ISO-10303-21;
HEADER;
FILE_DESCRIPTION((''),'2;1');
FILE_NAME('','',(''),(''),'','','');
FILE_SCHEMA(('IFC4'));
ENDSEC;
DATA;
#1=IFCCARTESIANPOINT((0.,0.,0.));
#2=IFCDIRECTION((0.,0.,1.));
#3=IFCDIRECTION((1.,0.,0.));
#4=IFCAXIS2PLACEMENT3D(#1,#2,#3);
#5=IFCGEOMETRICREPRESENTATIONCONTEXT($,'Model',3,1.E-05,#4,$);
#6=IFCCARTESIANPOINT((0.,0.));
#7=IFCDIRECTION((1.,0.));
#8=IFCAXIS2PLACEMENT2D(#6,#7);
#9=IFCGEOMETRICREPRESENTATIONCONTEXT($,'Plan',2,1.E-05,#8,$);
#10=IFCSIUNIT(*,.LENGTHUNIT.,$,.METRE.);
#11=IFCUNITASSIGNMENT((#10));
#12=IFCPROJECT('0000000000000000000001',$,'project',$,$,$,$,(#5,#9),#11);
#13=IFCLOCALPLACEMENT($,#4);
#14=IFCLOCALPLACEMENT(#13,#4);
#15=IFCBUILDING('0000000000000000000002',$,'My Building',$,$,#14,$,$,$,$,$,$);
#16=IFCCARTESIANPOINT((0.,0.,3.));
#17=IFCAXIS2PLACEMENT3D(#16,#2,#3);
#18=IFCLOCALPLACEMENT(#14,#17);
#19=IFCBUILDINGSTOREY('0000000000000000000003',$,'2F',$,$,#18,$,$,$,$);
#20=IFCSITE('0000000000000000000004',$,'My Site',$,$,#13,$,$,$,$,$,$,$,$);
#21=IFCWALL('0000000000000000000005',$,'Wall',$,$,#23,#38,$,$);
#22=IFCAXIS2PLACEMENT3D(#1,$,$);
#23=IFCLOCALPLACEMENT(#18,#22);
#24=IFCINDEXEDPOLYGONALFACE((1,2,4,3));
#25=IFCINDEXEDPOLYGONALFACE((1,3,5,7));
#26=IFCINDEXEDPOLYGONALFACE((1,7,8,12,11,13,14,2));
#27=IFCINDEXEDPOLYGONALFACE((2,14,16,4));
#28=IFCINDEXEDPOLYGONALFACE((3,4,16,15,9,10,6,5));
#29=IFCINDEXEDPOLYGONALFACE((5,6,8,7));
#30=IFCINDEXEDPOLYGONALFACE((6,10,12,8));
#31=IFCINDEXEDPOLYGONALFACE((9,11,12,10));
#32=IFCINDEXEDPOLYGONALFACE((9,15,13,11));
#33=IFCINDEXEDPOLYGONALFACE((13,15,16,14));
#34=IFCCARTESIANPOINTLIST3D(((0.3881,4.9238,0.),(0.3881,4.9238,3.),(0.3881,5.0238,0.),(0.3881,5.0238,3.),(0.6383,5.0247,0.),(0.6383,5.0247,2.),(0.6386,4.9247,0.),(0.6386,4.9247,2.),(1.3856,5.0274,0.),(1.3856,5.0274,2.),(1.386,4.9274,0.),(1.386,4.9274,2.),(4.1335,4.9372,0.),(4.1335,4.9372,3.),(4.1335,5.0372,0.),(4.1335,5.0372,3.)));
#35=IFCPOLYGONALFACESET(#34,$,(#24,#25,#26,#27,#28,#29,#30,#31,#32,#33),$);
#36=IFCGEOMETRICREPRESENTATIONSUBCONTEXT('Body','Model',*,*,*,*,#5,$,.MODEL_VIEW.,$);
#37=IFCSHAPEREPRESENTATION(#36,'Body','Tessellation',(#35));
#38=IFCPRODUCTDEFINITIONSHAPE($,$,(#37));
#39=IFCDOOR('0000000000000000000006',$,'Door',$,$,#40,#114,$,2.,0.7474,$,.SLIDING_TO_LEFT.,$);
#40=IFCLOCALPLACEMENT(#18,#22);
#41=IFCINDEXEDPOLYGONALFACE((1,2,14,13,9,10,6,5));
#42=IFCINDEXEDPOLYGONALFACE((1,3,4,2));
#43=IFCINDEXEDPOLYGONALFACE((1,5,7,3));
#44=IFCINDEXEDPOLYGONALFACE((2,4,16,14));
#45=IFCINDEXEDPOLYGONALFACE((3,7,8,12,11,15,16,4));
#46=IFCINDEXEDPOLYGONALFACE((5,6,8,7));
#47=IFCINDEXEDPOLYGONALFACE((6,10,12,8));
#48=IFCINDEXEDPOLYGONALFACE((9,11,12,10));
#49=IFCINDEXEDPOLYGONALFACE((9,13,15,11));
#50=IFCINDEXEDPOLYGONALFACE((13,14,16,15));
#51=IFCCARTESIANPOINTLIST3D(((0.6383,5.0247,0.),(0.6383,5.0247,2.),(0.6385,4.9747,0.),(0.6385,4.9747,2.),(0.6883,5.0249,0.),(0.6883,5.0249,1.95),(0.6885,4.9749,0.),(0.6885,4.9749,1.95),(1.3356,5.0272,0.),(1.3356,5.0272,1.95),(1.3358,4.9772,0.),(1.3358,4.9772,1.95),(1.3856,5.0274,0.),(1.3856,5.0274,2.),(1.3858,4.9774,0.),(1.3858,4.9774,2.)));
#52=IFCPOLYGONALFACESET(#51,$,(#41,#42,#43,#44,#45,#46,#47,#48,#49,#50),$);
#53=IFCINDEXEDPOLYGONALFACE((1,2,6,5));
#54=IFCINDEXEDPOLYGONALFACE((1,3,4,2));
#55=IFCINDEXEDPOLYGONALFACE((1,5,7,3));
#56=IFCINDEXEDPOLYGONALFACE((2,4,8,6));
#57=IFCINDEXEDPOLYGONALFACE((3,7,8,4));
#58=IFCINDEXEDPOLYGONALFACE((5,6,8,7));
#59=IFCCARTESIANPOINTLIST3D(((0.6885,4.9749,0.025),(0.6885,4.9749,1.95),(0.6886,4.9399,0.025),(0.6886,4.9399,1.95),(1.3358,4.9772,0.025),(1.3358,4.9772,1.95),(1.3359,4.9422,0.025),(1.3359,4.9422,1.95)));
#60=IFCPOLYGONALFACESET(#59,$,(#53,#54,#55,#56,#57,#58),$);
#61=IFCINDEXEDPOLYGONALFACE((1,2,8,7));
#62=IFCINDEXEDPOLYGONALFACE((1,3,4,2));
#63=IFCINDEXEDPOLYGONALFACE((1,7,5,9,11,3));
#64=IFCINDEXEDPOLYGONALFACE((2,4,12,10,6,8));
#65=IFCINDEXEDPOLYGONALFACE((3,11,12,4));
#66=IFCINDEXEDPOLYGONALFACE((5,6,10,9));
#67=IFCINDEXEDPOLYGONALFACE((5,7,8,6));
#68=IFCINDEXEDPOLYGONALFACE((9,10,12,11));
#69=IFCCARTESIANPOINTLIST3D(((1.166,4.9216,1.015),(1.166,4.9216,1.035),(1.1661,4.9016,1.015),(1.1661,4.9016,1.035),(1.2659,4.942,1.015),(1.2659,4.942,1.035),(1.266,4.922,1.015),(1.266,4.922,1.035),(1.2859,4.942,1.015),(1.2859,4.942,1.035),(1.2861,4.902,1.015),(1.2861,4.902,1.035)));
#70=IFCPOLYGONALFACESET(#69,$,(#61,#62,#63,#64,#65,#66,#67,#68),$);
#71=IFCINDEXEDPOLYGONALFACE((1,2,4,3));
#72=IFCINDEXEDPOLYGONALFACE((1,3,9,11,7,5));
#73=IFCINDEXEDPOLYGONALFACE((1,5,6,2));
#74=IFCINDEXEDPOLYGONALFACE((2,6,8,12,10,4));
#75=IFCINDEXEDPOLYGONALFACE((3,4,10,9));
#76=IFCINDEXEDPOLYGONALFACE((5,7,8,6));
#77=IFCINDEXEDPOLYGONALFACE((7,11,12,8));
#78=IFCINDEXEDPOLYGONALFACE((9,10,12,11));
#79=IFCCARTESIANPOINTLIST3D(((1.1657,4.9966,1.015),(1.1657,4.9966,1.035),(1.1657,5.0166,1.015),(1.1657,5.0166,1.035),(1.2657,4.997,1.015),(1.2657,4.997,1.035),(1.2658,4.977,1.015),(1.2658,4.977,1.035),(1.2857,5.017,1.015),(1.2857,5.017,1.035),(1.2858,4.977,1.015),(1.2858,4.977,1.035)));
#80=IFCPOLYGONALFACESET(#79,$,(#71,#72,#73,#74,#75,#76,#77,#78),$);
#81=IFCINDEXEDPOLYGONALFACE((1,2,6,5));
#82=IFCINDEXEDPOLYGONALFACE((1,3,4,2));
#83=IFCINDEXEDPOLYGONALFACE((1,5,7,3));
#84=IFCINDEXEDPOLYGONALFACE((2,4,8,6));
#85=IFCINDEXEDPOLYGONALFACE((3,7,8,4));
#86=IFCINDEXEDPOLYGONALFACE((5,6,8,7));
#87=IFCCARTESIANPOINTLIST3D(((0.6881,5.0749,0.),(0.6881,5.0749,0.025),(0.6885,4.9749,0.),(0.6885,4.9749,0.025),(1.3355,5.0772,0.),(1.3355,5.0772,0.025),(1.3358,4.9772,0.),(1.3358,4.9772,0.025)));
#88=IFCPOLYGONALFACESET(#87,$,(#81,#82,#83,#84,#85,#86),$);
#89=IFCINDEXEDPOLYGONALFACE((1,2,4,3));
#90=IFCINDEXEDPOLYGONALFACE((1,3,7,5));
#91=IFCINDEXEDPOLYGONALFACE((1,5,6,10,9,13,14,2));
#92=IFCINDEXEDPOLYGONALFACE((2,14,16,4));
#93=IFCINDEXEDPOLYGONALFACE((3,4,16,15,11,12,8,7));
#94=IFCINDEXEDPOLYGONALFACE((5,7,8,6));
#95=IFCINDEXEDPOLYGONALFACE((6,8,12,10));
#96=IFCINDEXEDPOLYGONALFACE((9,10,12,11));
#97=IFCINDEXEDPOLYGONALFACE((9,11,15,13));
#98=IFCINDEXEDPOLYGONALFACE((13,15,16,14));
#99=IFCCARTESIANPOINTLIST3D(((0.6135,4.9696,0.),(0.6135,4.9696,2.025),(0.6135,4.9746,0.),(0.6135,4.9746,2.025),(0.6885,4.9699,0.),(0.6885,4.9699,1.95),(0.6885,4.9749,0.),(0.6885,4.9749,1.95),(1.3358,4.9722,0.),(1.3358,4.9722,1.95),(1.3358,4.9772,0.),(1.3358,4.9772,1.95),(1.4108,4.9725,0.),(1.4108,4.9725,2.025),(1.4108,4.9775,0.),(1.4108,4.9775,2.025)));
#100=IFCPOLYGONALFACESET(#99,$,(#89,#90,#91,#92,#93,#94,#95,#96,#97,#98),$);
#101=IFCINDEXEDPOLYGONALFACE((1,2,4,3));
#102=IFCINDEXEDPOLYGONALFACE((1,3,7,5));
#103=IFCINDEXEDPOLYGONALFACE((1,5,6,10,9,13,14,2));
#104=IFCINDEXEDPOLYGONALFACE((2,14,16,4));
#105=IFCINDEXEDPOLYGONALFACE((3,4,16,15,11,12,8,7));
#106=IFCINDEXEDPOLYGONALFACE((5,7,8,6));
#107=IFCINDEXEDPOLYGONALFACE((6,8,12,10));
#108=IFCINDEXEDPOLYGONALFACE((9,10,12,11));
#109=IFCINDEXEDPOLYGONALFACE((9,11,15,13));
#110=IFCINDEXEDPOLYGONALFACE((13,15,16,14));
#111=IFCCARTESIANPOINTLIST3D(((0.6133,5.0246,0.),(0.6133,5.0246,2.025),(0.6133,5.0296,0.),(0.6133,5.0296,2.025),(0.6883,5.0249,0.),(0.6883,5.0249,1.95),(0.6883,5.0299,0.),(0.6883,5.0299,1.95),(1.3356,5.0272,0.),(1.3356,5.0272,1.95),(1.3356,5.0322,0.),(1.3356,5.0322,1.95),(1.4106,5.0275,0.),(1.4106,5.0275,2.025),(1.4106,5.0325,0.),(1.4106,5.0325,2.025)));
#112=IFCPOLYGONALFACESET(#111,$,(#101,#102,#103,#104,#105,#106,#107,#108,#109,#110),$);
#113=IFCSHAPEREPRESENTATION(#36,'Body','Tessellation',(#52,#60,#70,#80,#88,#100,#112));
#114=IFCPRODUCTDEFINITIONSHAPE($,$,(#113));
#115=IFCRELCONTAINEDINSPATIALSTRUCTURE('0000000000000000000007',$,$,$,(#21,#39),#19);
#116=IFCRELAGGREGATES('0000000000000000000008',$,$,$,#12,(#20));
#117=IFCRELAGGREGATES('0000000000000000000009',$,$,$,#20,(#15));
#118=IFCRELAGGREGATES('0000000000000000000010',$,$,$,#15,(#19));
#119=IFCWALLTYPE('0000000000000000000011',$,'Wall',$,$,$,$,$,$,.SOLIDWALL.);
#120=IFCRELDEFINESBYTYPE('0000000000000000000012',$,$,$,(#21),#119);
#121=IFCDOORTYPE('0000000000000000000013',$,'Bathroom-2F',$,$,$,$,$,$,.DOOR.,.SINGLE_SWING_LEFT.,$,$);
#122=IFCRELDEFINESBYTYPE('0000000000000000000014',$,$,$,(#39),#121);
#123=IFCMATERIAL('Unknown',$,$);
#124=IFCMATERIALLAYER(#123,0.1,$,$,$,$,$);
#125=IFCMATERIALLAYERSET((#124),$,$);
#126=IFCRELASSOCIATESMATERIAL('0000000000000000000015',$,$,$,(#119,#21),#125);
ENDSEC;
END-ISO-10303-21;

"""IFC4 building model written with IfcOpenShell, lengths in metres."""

from ifc_helpers import new_model, entity, si_unit, frame, origin_with_axes, origin_2d_with_axis, place, context, subcontext, project, spatial, line, indexed_curve, outline, extrude, shape, source, transform, mapped, material, layer, layer_set, layer_usage, type_object, type_shapes, element, fill, save


model = new_model("IFC4")

# Units and contexts
model_context = context("Model", 3, precision=1e-05, world=origin_with_axes())
plan_context = context("Plan", 2, precision=1e-05, world=origin_2d_with_axis())
body_context_1 = subcontext(model_context, "Body", "Model", "MODEL_VIEW")
body_context_2 = subcontext(plan_context, "Body", "Plan", "PLAN_VIEW")
ifc_project = project(units=[si_unit("LENGTHUNIT", "METRE")], contexts=[model_context, plan_context])

# Site, building, storey
site_placement = place(None, origin_with_axes())
site = spatial("IfcSite", under=ifc_project, at=site_placement, Name="My Site")
building_placement = place(site_placement, origin_with_axes())
building = spatial("IfcBuilding", under=site, at=building_placement, Name="My Building")
storey_placement = place(building_placement, frame((0.0, 0.0, 3.0), z_axis=(0.0, 0.0, 1.0), x_axis=(1.0, 0.0, 0.0)))
storey = spatial("IfcBuildingStorey", under=building, at=storey_placement, Name="2F")

# Shared definitions
ifc_material = material(Name="Unknown")

# Shared definitions
ifc_layer_1 = layer(ifc_material, 0.1)
ifc_layer_set_1 = layer_set([ifc_layer_1])
wall_type = type_object("IfcWallType", Name="Wall", PredefinedType="SOLIDWALL", material=ifc_layer_set_1)

# Wall, opening, door
ifc_layer_usage_1 = layer_usage(ifc_layer_set_1, "AXIS2", "POSITIVE", 0.0)
wall_1_placement = place(storey_placement, frame((0.3881, 4.9238, 0.0), z_axis=(0.0, 0.0, 1.0), x_axis=(0.999994, 0.003582, 0.0)))
wall_1 = element("IfcWall", 1, at=wall_1_placement, inside=storey, type_object=wall_type, material=ifc_layer_usage_1, Name="Wall", context=body_context_1, shape_type="SweptSolid", body=[
    extrude(outline(indexed_curve([(0.0, 0.0), (0.0004, 0.1), (3.7458, 0.1), (3.7454, 0.0)], segments=[line(1, 2, 3, 4, 1)])), origin_with_axes(), (0.0, 0.0, 1.0), 3.0),
])
shared_shape_1 = source(origin_with_axes(), body_context_1, "Body", "SweptSolid", [
    extrude(outline(indexed_curve([(0.0, 0.0), (0.7474, 0.0), (0.7474, 2.0), (0.0, 2.0)], segments=[line(1, 2, 3, 4, 1)])), frame((0.0, -0.6, 0.0), z_axis=(0.0, -1.0, 0.0), x_axis=(1.0, 0.0, 0.0)), (0.0, 0.0, -1.0), 1.2),
])
opening_1_placement = place(wall_1_placement, frame((0.2505, 0.05, 0.0), z_axis=(0.0, 0.0, 1.0), x_axis=(1.0, -0.000001, 0.0)))
opening_1 = element("IfcOpeningElement", 2, at=opening_1_placement, cuts=wall_1, PredefinedType="OPENING", context=body_context_1, shape_type="MappedRepresentation", body=[
    mapped(shared_shape_1, transform((0.0, 0.0, 0.0), x_axis=(1.0, 0.0, 0.0), y_axis=(0.0, 1.0, 0.0), z_axis=(0.0, 0.0, 1.0), scale=1.0)),
])
door_type_1 = type_object("IfcDoorType", Name="Bathroom-2F", OperationType="SINGLE_SWING_LEFT", PredefinedType="DOOR")
shared_shape_2 = source(origin_with_axes(), body_context_1, "Body", "SweptSolid", [
    extrude(outline(indexed_curve([(0.0, 0.0), (0.0, 2.0), (0.7474, 2.0), (0.7474, 0.0), (0.6974, 0.0), (0.6974, 1.95), (0.05, 1.95), (0.05, 0.0)], segments=[line(1, 2, 3, 4, 5, 6, 7, 8, 1)])), frame((0.0, 0.0, 0.0), z_axis=(0.0, -1.0, 0.0), x_axis=(1.0, 0.0, 0.0)), (0.0, 0.0, -1.0), 0.05),
    extrude(outline(indexed_curve([(0.0, 0.0), (0.6474, 0.0), (0.6474, 0.035), (0.0, 0.035)], segments=[line(1, 2, 3, 4, 1)])), frame((0.05, -0.035, 0.025), z_axis=(0.0, 0.0, 1.0), x_axis=(1.0, 0.0, 0.0)), (0.0, 0.0, 1.0), 1.925),
    extrude(outline(indexed_curve([(0.0, 0.0), (0.0, -0.04), (-0.12, -0.04), (-0.12, -0.02), (-0.02, -0.02), (-0.02, 0.0)], segments=[line(1, 2, 3, 4, 5, 6, 1)])), frame((0.6474, -0.035, 1.015), z_axis=(0.0, 0.0, 1.0), x_axis=(1.0, 0.0, 0.0)), (0.0, 0.0, 1.0), 0.02),
    extrude(outline(indexed_curve([(0.0, 0.0), (0.0, 0.04), (-0.12, 0.04), (-0.12, 0.02), (-0.02, 0.02), (-0.02, 0.0)], segments=[line(1, 2, 3, 4, 5, 6, 1)])), frame((0.6474, 0.0, 1.015), z_axis=(0.0, 0.0, 1.0), x_axis=(1.0, 0.0, 0.0)), (0.0, 0.0, 1.0), 0.02),
    extrude(outline(indexed_curve([(0.0, 0.0), (0.6474, 0.0), (0.6474, 0.1), (0.0, 0.1)], segments=[line(1, 2, 3, 4, 1)])), frame((0.05, 0.0, 0.0), z_axis=(0.0, 0.0, 1.0), x_axis=(1.0, 0.0, 0.0)), (0.0, 0.0, 1.0), 0.025),
    extrude(outline(indexed_curve([(0.0, 0.0), (0.0, 2.025), (0.7974, 2.025), (0.7974, 0.0), (0.7224, 0.0), (0.7224, 1.95), (0.075, 1.95), (0.075, 0.0)], segments=[line(1, 2, 3, 4, 5, 6, 7, 8, 1)])), frame((-0.025, -0.005, 0.0), z_axis=(0.0, -1.0, 0.0), x_axis=(1.0, 0.0, 0.0)), (0.0, 0.0, -1.0), 0.005),
    extrude(outline(indexed_curve([(0.0, 0.0), (0.0, 2.025), (0.7974, 2.025), (0.7974, 0.0), (0.7224, 0.0), (0.7224, 1.95), (0.075, 1.95), (0.075, 0.0)], segments=[line(1, 2, 3, 4, 5, 6, 7, 8, 1)])), frame((-0.025, 0.05, 0.0), z_axis=(0.0, -1.0, 0.0), x_axis=(1.0, 0.0, 0.0)), (0.0, 0.0, -1.0), 0.005),
])
shared_shape_3 = source(origin_with_axes(), body_context_2, "Body", "Curve2D", [
    entity("IfcIndexedPolyCurve", entity("IfcCartesianPointList2D", [[0.0, 0.0], [0.05, 0.0], [0.05, 0.05], [0.0, 0.05]]), [entity("IfcLineIndex", [1, 2, 3, 4, 1])]),
    entity("IfcIndexedPolyCurve", entity("IfcCartesianPointList2D", [[0.7474, 0.0], [0.6974, 0.0], [0.6974, 0.05], [0.7474, 0.05]]), [entity("IfcLineIndex", [1, 2, 3, 4, 1])]),
    entity("IfcIndexedPolyCurve", entity("IfcCartesianPointList2D", [[-0.2737, -0.035], [0.3737, -0.035], [0.3737, 0.0], [-0.2737, 0.0]]), [entity("IfcLineIndex", [1, 2, 3, 4, 1])]),
])
type_shapes(door_type_1, [shared_shape_2, shared_shape_3])
door_1_placement = place(opening_1_placement, frame((0.0, 0.0, 0.0), z_axis=(0.0, 0.0, 1.0), x_axis=(1.0, 0.0, 0.0)))
door_1 = element("IfcDoor", 3, at=door_1_placement, inside=storey, type_object=door_type_1, Name="Door", OperationType="SLIDING_TO_LEFT", OverallHeight=2.0, OverallWidth=0.7474, shapes=[
    shape(body_context_1, "Body", "MappedRepresentation", [mapped(shared_shape_2, transform((0.0, 0.0, 0.0), x_axis=(1.0, 0.0, 0.0), y_axis=(0.0, 1.0, 0.0), z_axis=(0.0, 0.0, 1.0), scale=1.0))]),
    shape(body_context_2, "Body", "MappedRepresentation", [mapped(shared_shape_3, transform((0.0, 0.0, 0.0), x_axis=(1.0, 0.0, 0.0), y_axis=(0.0, 1.0, 0.0), z_axis=(0.0, 0.0, 1.0), scale=1.0))]),
])
fill(opening_1, door_1)

save(model, "model.ifc")
